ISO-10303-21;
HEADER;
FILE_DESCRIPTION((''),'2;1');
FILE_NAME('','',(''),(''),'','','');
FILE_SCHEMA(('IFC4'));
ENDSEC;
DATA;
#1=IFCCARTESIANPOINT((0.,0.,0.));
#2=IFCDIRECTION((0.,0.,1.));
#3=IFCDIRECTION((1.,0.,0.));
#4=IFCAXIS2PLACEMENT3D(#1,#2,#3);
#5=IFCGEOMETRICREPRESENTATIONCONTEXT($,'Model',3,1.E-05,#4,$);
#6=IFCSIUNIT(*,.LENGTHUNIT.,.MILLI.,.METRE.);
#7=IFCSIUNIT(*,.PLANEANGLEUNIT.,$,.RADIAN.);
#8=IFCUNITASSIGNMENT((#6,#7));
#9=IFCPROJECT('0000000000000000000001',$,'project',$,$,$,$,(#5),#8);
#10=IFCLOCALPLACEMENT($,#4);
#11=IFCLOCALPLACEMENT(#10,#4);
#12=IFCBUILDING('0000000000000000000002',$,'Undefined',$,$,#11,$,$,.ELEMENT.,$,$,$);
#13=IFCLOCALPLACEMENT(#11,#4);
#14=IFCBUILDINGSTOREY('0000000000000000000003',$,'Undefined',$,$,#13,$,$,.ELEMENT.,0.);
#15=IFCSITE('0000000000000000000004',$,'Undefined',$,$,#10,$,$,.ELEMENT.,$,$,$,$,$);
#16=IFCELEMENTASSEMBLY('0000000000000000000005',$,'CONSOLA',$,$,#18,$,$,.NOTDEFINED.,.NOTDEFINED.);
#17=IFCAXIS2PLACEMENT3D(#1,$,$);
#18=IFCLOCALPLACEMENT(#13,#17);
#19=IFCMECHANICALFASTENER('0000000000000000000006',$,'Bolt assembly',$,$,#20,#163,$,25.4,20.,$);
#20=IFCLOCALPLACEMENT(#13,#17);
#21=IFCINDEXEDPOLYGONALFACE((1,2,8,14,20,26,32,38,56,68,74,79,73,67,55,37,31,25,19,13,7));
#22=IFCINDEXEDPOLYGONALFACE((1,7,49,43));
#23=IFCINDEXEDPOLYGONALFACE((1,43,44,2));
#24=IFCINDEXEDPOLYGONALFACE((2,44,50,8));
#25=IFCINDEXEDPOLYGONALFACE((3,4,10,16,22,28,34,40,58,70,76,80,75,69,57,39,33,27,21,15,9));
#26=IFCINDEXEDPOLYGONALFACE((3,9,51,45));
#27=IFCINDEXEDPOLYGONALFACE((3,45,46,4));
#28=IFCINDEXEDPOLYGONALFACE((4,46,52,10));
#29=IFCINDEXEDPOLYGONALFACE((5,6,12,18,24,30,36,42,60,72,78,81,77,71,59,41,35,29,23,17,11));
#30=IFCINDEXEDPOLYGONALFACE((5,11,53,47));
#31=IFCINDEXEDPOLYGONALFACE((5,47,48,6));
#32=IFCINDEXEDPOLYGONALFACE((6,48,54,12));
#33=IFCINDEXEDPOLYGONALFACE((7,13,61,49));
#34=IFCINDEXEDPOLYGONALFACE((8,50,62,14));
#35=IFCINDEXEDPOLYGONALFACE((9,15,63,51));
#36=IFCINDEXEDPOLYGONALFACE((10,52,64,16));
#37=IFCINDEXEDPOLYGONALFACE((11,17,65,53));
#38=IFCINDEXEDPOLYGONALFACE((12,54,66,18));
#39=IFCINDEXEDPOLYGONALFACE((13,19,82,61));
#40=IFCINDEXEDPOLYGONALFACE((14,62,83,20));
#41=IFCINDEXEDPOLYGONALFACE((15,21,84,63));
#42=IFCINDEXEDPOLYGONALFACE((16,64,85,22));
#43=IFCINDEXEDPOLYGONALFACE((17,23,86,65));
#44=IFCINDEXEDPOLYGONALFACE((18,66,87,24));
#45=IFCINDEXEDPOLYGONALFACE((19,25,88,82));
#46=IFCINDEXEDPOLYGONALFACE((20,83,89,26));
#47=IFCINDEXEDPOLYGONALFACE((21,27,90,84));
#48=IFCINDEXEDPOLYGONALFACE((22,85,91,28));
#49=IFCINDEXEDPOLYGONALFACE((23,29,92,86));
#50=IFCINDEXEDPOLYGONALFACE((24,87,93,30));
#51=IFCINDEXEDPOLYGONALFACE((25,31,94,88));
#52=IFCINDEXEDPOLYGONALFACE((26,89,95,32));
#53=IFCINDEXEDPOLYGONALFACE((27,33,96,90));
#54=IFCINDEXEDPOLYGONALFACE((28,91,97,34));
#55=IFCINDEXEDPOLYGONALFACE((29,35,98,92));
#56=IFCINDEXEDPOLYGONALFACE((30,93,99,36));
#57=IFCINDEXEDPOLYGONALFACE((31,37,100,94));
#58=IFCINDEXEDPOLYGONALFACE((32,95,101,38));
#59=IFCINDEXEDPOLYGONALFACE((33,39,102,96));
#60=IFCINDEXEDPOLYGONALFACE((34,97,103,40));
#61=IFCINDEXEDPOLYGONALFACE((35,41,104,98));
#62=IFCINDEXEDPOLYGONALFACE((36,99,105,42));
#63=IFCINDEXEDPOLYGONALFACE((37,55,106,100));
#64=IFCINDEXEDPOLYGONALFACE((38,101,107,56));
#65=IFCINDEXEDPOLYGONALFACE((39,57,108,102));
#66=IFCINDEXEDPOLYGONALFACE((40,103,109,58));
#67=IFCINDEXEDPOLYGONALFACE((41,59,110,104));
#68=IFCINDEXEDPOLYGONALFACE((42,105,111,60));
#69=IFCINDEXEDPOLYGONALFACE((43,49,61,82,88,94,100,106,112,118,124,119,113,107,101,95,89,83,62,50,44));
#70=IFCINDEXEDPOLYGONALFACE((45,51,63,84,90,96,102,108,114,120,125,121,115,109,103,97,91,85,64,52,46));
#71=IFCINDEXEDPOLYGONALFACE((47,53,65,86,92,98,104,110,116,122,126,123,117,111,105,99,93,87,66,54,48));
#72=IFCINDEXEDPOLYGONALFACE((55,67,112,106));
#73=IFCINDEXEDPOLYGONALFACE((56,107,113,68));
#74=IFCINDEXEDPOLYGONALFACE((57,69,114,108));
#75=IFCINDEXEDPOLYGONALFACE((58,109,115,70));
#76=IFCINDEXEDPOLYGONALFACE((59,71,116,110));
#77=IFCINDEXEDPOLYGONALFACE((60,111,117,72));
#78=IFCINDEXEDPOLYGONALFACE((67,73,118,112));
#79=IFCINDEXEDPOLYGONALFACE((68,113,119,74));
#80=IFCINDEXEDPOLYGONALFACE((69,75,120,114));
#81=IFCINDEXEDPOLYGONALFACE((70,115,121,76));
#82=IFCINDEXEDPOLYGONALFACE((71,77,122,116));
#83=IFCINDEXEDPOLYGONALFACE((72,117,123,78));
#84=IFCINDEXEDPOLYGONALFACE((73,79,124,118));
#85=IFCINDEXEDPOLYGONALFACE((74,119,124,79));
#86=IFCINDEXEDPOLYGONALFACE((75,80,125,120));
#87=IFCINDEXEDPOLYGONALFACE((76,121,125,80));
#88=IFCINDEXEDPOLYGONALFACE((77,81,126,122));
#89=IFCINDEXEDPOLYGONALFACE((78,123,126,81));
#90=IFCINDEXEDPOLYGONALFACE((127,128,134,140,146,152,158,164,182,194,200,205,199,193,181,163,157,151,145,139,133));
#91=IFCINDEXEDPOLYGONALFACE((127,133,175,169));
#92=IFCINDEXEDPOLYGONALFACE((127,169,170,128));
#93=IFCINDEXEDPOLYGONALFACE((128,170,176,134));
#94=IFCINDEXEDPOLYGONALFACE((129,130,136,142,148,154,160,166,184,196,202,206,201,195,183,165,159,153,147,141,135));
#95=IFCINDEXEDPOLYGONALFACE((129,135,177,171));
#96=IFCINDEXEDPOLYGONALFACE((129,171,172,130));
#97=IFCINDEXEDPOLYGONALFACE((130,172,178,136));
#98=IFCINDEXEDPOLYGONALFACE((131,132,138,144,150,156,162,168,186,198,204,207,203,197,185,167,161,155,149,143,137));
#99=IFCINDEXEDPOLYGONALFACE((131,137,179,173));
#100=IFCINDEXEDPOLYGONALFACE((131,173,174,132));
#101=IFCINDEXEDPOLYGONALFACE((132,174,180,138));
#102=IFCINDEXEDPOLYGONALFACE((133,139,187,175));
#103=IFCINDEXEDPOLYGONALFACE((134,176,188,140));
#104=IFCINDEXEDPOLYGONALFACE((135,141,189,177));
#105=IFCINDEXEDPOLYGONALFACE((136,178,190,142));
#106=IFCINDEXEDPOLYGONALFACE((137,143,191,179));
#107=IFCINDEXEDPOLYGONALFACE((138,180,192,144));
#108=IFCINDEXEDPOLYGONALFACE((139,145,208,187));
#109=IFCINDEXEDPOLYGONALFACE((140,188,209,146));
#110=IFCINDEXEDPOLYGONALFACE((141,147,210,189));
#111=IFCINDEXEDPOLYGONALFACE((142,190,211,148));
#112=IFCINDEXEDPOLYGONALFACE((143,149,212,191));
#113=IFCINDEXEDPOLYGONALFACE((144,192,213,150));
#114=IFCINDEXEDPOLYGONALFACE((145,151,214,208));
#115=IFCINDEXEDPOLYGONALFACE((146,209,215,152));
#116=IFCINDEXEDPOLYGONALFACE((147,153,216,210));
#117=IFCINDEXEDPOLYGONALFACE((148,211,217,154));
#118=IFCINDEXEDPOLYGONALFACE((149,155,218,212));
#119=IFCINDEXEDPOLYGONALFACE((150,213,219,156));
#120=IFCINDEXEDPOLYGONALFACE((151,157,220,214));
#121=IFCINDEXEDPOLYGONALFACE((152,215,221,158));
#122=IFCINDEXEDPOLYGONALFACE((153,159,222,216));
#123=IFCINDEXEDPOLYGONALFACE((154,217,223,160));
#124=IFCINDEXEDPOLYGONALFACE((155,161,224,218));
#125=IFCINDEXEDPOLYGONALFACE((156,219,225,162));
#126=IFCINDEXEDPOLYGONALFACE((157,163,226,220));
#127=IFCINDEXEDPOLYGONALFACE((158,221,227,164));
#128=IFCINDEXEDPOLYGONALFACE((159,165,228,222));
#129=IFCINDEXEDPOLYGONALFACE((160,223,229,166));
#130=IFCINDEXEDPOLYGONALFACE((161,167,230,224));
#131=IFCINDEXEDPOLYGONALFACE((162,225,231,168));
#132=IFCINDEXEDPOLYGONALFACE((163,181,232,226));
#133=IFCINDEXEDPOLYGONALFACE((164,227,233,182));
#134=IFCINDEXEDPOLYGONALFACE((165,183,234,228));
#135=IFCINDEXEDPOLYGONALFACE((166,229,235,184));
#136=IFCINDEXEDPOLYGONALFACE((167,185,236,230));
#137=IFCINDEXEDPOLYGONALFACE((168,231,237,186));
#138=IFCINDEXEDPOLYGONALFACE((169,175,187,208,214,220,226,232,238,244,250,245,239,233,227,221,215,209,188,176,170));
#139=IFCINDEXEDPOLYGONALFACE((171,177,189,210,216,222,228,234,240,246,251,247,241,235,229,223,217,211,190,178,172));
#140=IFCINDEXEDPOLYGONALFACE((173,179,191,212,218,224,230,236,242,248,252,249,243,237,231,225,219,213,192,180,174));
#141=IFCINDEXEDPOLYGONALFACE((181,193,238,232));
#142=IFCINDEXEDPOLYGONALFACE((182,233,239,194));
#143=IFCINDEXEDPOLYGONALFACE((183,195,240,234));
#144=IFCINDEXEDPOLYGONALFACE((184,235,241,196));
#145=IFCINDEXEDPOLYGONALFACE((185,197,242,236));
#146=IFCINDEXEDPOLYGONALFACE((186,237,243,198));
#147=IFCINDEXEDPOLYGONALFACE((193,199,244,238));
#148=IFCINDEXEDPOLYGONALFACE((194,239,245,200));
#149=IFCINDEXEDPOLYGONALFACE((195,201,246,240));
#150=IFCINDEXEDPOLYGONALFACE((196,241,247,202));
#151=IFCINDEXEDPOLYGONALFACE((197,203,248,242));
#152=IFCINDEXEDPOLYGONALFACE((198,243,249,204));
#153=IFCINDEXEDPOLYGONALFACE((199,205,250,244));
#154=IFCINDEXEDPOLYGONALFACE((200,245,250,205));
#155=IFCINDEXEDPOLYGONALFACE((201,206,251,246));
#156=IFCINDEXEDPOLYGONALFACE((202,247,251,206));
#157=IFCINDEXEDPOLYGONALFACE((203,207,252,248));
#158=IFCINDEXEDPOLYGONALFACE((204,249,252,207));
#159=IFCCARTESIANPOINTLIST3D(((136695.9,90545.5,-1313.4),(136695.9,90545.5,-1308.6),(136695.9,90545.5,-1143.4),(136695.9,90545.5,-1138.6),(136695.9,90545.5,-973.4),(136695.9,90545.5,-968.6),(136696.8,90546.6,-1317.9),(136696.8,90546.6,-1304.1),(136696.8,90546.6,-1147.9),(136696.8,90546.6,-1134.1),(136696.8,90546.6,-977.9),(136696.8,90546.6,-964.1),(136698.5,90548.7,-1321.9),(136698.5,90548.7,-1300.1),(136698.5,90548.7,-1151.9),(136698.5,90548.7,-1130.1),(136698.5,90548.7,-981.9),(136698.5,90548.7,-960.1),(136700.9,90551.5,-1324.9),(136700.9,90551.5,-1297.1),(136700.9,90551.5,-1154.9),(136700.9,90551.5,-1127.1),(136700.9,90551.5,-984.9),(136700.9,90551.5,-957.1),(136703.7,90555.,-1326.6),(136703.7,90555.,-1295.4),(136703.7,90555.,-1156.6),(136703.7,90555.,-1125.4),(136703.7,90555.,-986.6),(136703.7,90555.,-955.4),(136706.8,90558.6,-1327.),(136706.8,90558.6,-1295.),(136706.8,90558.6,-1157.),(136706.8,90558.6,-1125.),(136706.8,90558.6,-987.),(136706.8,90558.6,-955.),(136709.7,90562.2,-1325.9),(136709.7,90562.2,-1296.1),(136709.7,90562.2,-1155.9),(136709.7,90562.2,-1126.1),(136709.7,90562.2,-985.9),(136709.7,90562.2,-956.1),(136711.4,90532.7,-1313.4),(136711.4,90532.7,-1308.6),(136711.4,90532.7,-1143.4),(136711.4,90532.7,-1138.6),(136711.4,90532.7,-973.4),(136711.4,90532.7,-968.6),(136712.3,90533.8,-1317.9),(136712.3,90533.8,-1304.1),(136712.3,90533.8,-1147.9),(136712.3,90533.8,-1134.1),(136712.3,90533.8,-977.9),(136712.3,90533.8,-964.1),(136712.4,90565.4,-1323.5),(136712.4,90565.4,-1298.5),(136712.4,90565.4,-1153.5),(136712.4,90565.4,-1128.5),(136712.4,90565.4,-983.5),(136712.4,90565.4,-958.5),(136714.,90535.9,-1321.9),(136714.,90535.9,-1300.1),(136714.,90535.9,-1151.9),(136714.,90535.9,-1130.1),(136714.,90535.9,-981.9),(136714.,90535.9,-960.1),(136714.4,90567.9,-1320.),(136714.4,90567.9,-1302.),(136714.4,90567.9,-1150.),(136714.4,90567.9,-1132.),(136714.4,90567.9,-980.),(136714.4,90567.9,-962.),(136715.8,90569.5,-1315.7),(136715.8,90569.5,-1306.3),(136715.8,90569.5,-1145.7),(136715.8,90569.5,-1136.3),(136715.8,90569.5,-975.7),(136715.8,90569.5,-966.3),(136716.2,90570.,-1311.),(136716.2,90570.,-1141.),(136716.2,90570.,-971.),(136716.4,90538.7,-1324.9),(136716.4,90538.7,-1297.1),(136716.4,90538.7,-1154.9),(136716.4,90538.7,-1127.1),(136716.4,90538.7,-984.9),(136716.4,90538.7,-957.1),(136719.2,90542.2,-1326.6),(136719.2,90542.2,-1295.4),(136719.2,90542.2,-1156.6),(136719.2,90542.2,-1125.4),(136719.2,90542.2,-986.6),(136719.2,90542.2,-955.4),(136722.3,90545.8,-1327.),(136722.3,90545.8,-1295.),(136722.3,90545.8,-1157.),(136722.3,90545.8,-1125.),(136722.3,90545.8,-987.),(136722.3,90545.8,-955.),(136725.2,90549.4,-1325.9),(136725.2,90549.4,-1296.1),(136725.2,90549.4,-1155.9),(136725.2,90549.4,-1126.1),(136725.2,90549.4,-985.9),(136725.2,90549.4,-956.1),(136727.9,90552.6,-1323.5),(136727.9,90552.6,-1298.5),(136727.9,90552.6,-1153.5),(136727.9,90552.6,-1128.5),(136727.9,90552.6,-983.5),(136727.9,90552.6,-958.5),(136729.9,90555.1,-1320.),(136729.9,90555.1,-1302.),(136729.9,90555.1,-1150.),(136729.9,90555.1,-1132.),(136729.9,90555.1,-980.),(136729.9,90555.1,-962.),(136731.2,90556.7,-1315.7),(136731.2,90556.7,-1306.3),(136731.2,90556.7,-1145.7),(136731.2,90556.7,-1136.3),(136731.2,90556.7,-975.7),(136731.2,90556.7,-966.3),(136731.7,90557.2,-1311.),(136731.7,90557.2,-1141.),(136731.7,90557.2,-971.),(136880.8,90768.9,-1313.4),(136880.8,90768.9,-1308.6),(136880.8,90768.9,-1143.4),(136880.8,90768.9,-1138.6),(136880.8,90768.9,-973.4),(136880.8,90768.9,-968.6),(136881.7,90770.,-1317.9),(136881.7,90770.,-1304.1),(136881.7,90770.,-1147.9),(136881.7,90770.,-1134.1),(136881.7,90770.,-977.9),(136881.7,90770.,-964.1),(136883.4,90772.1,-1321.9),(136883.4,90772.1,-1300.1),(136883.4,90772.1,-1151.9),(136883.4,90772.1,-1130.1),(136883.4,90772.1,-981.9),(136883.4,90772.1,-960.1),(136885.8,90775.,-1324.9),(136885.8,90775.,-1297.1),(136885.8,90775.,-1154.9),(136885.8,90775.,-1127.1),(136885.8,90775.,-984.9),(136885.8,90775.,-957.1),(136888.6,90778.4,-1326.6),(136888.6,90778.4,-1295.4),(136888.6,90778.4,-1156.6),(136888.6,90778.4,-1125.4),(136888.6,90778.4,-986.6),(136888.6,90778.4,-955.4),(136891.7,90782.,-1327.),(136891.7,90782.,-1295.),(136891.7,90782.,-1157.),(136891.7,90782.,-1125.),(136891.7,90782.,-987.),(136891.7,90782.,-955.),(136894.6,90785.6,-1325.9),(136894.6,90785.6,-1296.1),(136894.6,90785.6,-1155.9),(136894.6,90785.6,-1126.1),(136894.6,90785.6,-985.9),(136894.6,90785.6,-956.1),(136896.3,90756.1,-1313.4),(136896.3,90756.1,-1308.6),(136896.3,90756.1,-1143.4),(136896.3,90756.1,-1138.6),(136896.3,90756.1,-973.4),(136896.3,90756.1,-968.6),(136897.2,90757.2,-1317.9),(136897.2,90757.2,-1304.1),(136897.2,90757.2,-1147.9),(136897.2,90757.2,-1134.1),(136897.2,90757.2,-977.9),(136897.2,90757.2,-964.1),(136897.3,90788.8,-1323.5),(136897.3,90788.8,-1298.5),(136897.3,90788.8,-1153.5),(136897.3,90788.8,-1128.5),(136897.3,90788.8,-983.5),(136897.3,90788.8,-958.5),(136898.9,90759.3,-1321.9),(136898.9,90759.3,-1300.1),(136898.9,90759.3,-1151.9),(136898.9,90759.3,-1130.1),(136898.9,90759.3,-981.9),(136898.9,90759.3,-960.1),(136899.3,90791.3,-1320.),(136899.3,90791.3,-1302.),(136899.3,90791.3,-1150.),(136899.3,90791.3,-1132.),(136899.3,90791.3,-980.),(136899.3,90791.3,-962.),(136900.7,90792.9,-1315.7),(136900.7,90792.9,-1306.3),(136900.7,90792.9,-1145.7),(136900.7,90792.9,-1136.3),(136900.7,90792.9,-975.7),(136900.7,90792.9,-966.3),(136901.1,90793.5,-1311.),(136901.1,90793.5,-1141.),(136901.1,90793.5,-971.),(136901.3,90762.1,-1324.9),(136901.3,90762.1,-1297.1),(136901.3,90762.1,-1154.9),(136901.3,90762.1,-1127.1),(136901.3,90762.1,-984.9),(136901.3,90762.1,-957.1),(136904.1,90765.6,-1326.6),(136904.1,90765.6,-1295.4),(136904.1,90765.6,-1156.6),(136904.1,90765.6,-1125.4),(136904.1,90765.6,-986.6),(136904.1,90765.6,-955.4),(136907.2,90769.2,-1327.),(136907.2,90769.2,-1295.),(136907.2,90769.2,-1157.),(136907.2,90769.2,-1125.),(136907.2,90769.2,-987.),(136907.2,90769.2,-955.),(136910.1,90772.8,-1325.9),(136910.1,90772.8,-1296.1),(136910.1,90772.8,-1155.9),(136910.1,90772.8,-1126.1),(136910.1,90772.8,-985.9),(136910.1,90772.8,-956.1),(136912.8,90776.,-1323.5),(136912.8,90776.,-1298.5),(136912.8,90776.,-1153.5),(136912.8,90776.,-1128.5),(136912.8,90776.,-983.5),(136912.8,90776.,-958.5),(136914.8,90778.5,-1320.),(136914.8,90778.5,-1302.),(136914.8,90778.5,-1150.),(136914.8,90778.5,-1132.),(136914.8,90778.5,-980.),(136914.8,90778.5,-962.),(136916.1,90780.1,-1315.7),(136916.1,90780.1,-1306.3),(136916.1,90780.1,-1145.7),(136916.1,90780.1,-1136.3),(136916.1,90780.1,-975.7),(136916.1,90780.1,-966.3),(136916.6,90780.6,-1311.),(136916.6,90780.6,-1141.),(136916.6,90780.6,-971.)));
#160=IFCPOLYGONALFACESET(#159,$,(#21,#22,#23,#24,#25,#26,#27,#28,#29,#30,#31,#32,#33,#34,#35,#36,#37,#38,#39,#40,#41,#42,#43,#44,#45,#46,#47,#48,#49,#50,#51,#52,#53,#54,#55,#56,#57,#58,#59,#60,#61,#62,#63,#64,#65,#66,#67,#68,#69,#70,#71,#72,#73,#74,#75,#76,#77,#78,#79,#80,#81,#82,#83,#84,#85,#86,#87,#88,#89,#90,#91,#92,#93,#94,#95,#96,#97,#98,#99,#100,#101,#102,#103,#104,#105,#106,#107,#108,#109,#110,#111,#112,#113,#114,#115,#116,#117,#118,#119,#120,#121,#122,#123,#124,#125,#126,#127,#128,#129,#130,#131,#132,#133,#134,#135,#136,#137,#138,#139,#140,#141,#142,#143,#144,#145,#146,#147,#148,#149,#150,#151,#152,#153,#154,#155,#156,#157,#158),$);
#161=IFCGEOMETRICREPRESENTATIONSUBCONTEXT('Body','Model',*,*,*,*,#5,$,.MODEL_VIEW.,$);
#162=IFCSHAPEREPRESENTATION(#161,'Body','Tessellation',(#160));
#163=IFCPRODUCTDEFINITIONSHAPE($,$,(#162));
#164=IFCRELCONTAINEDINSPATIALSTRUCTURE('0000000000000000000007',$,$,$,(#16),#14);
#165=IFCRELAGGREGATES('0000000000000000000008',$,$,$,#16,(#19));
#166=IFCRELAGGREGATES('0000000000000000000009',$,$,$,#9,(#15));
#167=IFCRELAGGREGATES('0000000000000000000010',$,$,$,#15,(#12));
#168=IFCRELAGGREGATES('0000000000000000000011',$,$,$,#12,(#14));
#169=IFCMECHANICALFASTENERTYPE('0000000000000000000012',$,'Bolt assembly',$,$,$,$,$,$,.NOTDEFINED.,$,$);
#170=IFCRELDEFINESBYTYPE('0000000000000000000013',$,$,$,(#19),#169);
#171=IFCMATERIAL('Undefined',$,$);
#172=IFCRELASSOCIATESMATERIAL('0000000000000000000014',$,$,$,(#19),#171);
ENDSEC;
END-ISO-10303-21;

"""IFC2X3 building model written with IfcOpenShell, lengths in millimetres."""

from ifc_helpers import new_model, si_unit, frame, origin_with_axes, origin_2d_with_axis, place, context, subcontext, project, spatial, circle, extrude, source, transform, mapped, material, type_object, element, aggregate, save


model = new_model("IFC2X3")

# Units and contexts
model_context = context("Model", 3, precision=1e-05, world=origin_with_axes())
body_context = subcontext(model_context, "Body", "Model", "MODEL_VIEW")
ifc_project = project(units=[si_unit("LENGTHUNIT", "METRE", prefix="MILLI"), si_unit("PLANEANGLEUNIT", "RADIAN")], contexts=[model_context])

# Site, building, storey
site_placement = place(None, origin_with_axes())
site = spatial("IfcSite", under=ifc_project, at=site_placement, Name="Undefined", CompositionType="ELEMENT")
building_placement = place(site_placement, origin_with_axes())
building = spatial("IfcBuilding", under=site, at=building_placement, Name="Undefined", CompositionType="ELEMENT")
storey_placement = place(building_placement, origin_with_axes())
storey = spatial("IfcBuildingStorey", under=building, at=storey_placement, Name="Undefined", CompositionType="ELEMENT", Elevation=0.0)

# Element assembly
assembly_1_placement = place(storey_placement, origin_with_axes())
assembly_1 = element("IfcElementAssembly", 1, at=assembly_1_placement, inside=storey, Name="CONSOLA", AssemblyPlace="NOTDEFINED", PredefinedType="NOTDEFINED")

# Shared definitions
ifc_material_1 = material(Name="Undefined")
mechanical_fastener_type = type_object("IfcMechanicalFastenerType", Name="Bolt assembly")

# Mechanical fastener
shared_shape_1 = source(origin_with_axes(), body_context, "Body", "SweptSolid", [
    extrude(circle(Radius=16.0, at=origin_2d_with_axis()), frame((0.0, -4.0, 0.0), z_axis=(0.0, 1.0, 0.0), x_axis=(1.0, 0.0, 0.0)), (0.0, 0.0, 1.0), 20.1),
])
mechanical_fastener_1_placement = place(assembly_1_placement, frame((136718.4, 90547.4, -1141.0), z_axis=(0.000001, 0.000001, 1.0), x_axis=(0.63756, 0.770401, -0.000002)))
mechanical_fastener_1 = element("IfcMechanicalFastener", 2, at=mechanical_fastener_1_placement, type_object=mechanical_fastener_type, material=ifc_material_1, Name="Bolt assembly", NominalDiameter=25.4, NominalLength=20.0, context=body_context, shape_type="MappedRepresentation", body=[
    mapped(shared_shape_1, transform((0.0, 0.0, -170.0))),
    mapped(shared_shape_1, transform((290.0, 0.0, -170.0))),
    mapped(shared_shape_1, transform((0.0, 0.0, 0.0))),
    mapped(shared_shape_1, transform((290.0, 0.0, 0.0))),
    mapped(shared_shape_1, transform((0.0, 0.0, 170.0))),
    mapped(shared_shape_1, transform((290.0, 0.0, 170.0))),
])
aggregate(assembly_1, [mechanical_fastener_1])

save(model, "model.ifc")
